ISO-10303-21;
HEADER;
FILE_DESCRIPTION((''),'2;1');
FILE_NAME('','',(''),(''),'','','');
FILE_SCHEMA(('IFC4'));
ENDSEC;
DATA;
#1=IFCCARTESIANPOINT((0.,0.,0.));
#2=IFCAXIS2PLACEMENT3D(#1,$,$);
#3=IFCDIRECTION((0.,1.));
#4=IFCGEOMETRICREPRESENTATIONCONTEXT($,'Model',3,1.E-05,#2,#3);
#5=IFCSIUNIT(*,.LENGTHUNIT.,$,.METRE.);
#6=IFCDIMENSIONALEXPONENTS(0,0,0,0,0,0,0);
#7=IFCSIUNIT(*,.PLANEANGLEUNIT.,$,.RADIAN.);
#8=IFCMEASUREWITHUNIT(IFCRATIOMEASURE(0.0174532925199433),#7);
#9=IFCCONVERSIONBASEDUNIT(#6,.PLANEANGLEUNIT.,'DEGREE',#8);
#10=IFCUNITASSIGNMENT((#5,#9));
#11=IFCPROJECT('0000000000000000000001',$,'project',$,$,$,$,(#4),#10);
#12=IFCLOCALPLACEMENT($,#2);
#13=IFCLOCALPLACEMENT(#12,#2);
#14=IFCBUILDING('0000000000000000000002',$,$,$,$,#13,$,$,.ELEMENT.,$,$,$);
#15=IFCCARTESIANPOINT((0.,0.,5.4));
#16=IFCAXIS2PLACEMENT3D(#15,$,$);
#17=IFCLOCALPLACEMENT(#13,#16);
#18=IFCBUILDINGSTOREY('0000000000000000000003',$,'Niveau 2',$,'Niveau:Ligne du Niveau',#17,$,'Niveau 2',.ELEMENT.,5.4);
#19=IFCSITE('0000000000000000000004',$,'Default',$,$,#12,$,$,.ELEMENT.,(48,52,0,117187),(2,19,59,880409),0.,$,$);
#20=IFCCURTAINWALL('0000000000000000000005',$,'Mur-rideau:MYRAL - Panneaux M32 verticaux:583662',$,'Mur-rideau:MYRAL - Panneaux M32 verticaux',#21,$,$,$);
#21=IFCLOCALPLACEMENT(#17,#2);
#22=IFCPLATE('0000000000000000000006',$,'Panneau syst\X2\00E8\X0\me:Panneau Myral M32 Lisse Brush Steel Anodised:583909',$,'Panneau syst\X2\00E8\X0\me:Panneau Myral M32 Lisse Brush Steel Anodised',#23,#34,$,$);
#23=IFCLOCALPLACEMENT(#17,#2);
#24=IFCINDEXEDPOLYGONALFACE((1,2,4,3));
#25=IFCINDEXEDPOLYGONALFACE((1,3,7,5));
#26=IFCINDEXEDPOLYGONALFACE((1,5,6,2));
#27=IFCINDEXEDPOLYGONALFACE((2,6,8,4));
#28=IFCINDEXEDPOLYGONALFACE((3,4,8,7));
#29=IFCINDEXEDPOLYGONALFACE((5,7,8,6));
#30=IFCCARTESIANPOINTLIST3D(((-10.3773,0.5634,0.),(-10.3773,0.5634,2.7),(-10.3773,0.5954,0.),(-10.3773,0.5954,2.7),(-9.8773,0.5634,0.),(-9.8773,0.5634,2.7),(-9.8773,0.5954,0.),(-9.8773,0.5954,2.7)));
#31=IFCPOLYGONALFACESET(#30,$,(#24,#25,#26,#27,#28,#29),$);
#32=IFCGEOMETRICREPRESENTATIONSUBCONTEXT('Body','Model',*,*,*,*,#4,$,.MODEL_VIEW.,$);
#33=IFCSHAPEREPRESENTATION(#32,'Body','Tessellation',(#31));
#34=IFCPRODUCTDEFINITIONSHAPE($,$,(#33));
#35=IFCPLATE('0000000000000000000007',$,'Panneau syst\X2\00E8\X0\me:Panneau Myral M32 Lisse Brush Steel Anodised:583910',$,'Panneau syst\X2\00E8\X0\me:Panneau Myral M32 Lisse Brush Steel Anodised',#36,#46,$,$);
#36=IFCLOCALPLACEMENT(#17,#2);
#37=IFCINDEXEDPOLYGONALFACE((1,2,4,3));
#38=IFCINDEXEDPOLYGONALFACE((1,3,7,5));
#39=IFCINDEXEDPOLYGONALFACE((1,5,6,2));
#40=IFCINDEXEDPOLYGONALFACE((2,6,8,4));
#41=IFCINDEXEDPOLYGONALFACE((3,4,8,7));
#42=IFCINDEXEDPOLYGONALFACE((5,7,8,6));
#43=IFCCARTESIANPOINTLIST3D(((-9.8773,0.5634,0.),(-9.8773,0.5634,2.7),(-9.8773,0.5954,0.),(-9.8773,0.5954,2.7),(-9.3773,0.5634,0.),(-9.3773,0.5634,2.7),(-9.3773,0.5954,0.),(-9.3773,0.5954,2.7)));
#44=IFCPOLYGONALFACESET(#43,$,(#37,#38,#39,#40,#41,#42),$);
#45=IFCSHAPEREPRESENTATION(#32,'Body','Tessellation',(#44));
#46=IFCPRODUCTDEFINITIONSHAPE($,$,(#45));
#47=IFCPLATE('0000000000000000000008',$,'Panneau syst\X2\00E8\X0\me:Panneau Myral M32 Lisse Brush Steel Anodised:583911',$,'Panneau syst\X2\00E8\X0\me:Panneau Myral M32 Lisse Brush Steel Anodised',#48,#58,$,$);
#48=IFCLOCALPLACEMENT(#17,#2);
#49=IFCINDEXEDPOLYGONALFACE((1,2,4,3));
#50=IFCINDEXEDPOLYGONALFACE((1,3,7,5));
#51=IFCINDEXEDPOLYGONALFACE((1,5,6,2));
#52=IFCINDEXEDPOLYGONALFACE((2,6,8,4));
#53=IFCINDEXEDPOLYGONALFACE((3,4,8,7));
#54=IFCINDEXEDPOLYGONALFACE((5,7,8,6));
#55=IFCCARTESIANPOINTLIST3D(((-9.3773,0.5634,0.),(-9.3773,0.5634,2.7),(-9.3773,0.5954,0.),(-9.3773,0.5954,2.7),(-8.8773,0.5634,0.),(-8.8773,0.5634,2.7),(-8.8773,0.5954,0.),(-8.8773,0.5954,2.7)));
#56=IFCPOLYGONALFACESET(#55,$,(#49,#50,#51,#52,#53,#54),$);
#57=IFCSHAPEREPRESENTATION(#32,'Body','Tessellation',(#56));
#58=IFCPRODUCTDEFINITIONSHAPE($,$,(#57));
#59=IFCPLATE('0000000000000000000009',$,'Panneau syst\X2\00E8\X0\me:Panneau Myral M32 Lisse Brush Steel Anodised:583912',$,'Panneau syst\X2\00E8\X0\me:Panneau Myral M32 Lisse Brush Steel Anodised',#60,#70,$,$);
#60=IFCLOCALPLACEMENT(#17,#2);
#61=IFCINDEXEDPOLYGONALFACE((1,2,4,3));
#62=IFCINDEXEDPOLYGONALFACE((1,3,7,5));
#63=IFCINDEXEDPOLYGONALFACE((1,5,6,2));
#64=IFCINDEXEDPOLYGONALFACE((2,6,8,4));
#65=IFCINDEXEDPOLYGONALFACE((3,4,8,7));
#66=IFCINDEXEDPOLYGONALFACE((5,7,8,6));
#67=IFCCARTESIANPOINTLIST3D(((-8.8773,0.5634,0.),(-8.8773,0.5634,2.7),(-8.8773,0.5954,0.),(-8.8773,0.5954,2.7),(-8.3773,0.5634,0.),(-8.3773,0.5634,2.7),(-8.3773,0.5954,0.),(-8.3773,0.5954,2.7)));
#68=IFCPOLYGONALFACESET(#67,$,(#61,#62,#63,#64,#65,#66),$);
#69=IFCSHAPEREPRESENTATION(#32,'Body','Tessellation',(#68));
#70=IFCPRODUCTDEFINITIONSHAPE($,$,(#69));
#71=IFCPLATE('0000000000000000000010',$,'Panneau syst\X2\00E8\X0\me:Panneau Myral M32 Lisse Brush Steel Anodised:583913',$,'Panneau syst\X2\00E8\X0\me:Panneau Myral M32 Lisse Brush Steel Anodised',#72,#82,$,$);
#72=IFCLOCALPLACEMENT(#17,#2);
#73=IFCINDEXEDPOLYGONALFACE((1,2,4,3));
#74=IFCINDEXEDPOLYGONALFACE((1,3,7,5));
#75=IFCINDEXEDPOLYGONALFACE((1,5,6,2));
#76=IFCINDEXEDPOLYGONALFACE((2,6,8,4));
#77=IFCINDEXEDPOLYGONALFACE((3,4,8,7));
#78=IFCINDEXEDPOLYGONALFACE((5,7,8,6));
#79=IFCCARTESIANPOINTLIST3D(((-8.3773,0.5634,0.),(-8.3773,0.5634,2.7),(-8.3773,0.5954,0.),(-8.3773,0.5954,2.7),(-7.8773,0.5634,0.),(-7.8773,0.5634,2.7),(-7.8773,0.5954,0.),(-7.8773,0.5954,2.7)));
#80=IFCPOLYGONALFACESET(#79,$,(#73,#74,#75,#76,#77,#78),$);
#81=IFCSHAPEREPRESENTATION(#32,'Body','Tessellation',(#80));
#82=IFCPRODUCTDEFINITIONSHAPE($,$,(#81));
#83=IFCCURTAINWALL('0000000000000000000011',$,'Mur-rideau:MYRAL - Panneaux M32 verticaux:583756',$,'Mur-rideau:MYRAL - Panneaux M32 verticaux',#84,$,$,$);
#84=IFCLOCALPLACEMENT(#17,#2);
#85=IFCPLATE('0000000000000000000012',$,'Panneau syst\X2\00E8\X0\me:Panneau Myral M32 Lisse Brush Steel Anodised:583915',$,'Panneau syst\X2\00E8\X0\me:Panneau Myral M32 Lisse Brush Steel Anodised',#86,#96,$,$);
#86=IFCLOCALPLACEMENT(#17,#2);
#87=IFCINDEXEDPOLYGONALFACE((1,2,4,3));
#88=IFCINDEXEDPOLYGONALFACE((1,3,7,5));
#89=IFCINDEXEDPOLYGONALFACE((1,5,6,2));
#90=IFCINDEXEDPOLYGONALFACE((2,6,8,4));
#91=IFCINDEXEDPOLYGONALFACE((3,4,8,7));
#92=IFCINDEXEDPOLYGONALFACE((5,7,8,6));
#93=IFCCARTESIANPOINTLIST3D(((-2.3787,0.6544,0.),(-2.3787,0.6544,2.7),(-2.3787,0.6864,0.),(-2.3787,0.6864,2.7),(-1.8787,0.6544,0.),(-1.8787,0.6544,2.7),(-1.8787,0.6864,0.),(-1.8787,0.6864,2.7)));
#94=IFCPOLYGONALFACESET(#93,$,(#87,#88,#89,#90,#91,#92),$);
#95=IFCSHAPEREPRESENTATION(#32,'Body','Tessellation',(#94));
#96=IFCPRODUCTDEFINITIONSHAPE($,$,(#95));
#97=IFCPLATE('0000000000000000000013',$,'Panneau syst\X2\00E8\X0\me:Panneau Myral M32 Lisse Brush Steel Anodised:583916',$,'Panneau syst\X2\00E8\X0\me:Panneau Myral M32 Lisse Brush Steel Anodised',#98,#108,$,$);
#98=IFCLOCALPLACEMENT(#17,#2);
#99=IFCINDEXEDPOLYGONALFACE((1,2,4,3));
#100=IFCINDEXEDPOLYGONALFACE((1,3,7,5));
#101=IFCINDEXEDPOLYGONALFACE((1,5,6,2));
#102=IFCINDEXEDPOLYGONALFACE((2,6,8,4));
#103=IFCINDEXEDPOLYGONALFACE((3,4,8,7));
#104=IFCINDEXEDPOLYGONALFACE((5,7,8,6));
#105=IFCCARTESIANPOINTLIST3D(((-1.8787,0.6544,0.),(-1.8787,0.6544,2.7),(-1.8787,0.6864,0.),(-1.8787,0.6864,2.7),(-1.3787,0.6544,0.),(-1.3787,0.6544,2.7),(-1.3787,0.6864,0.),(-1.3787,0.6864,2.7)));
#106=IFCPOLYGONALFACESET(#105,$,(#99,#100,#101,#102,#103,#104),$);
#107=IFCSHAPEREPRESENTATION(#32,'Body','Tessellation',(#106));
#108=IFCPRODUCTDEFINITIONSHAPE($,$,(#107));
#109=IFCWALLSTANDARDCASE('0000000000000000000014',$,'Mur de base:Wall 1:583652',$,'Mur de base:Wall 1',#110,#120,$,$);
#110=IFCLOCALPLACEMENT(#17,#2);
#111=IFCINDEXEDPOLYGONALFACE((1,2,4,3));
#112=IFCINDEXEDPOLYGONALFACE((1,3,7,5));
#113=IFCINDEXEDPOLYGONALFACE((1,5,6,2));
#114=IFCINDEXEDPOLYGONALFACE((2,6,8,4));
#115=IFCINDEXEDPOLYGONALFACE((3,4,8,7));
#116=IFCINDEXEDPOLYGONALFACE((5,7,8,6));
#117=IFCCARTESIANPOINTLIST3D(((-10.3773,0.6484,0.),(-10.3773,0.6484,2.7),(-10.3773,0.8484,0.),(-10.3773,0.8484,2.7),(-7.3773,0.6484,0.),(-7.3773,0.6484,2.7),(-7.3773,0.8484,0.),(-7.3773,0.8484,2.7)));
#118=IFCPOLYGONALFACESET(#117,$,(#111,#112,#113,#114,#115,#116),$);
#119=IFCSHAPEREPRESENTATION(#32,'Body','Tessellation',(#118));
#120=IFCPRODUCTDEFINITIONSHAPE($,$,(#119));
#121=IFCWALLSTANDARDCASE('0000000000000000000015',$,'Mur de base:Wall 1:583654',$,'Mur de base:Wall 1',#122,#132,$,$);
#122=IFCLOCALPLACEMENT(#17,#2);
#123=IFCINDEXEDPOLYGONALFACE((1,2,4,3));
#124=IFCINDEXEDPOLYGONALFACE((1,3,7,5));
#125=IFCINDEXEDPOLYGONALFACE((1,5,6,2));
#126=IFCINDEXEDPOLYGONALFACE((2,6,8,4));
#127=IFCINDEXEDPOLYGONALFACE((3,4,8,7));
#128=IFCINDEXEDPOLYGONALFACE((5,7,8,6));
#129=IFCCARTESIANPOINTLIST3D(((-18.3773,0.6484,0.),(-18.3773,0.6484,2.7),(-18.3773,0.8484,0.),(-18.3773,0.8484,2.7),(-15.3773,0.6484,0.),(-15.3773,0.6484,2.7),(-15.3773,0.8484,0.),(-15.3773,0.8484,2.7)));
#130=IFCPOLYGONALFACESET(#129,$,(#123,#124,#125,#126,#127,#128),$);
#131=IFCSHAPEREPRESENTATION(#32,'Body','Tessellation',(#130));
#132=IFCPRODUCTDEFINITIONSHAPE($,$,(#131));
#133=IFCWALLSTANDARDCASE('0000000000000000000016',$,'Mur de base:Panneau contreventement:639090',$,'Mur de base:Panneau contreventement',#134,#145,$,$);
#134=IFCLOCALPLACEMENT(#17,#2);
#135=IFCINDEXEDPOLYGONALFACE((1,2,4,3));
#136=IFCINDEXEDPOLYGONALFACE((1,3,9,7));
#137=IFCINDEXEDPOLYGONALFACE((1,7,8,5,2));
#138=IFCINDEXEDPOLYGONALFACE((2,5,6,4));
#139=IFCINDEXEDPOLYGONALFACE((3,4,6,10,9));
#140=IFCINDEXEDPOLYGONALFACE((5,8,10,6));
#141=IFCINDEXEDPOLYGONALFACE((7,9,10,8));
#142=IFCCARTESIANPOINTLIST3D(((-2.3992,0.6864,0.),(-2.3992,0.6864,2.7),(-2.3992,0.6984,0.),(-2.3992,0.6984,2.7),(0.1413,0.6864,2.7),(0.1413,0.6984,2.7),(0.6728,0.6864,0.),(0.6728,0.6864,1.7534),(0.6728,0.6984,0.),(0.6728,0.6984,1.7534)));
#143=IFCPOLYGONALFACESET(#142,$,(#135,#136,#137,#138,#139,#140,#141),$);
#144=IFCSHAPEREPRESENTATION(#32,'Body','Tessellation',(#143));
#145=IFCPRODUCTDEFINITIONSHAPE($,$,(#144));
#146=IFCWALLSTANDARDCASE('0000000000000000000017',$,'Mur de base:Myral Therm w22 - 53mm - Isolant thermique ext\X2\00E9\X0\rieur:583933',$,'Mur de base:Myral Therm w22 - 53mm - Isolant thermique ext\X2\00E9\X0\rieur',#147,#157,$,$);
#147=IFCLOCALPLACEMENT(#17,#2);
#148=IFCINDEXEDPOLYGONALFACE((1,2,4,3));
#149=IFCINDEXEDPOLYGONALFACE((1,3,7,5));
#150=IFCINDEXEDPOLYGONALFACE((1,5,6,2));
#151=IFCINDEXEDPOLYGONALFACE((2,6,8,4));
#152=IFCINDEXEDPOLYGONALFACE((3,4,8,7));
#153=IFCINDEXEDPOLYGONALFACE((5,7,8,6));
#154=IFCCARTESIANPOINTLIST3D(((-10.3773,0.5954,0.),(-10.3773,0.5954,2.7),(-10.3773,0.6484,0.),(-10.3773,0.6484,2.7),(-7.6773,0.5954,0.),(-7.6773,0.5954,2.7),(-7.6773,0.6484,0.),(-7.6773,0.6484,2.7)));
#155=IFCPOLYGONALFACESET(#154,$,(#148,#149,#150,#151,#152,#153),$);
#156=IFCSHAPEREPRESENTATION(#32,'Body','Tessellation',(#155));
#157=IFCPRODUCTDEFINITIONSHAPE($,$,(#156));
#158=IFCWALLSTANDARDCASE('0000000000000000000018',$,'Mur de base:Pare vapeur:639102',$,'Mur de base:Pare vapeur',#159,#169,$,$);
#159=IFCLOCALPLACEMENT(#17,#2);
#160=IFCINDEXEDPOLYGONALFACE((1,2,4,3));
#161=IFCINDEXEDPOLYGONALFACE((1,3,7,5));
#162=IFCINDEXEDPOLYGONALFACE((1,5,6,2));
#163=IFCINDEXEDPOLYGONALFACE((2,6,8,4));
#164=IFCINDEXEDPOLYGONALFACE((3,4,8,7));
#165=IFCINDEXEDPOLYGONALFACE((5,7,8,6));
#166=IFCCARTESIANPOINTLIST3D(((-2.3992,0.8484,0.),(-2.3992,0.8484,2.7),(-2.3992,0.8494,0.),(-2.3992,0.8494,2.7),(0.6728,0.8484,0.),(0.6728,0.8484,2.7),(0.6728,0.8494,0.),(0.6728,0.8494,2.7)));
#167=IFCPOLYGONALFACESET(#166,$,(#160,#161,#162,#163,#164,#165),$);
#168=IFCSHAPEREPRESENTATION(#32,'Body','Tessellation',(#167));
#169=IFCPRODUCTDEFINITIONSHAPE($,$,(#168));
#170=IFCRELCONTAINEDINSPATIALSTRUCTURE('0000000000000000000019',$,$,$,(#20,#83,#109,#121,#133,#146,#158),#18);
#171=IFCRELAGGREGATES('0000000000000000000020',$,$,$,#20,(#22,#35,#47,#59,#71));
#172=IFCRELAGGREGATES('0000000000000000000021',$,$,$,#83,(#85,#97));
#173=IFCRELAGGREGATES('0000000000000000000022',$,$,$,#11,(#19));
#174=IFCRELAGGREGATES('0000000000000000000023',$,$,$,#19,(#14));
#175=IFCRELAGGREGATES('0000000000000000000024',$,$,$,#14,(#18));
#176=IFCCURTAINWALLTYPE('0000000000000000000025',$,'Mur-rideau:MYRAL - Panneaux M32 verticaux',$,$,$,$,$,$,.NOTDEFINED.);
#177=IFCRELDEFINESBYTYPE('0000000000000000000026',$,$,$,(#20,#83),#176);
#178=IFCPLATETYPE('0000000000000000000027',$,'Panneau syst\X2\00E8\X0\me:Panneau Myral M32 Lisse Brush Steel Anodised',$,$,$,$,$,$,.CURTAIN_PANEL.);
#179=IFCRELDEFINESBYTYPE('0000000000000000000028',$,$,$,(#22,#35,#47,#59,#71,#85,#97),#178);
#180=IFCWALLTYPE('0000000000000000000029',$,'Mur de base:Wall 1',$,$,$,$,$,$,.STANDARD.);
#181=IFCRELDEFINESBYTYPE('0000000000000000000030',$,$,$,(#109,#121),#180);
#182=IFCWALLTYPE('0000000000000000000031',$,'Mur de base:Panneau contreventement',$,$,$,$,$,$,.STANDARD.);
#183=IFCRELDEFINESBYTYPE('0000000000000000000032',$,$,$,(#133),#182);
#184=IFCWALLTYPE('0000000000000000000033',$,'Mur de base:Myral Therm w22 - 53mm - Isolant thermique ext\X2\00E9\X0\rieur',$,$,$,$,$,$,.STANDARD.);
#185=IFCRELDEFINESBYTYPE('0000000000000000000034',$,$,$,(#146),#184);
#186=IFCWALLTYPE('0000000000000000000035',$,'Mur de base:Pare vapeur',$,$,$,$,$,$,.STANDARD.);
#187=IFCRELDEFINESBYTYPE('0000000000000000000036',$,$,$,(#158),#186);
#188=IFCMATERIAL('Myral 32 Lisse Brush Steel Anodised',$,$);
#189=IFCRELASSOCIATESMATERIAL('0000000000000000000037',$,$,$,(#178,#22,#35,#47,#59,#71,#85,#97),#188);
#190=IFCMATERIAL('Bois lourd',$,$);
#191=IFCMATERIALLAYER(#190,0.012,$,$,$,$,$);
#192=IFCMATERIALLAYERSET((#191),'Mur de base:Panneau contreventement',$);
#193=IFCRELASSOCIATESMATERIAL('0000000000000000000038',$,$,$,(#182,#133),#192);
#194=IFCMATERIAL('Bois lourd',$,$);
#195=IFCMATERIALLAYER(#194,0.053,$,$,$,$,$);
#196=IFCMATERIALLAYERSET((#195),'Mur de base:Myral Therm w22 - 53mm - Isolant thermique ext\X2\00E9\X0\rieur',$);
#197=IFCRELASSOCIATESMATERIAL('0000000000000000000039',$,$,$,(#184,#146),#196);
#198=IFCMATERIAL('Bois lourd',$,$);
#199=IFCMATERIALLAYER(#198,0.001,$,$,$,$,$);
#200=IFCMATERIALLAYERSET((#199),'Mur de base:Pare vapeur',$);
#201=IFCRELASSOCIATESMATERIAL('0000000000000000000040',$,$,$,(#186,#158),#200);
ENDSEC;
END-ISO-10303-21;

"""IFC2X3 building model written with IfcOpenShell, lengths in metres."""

from ifc_helpers import new_model, entity, si_unit, converted_unit, direction, frame, frame_2d, origin, origin_2d_with_axis, place, context, subcontext, project, spatial, rectangle, extrude, clip, halfspace, source, transform, mapped, material, layer, layer_set, layer_usage, type_object, type_shapes, element, aggregate, save


model = new_model("IFC2X3")

# Units and contexts
model_context = context("Model", 3, precision=1e-05, world=origin(), true_north=direction((0.0, 1.0)))
body_context = subcontext(model_context, "Body", "Model", "MODEL_VIEW")
ifc_project = project(units=[si_unit("LENGTHUNIT", "METRE"), converted_unit("PLANEANGLEUNIT", "DEGREE", entity("IfcRatioMeasure", 0.0174532925199433), si_unit("PLANEANGLEUNIT", "RADIAN"), dimensions=[0, 0, 0, 0, 0, 0, 0])], contexts=[model_context])

# Site, building, storey
site_placement = place(None, origin())
site = spatial("IfcSite", under=ifc_project, at=site_placement, Name="Default", CompositionType="ELEMENT", RefLatitude=(48, 52, 0, 117187), RefLongitude=(2, 19, 59, 880409), RefElevation=0.0)
building_placement = place(site_placement, origin())
building = spatial("IfcBuilding", under=site, at=building_placement, CompositionType="ELEMENT")
storey_placement = place(building_placement, frame((0.0, 0.0, 5.4)))
storey = spatial("IfcBuildingStorey", under=building, at=storey_placement, Name="Niveau 2", ObjectType="Niveau:Ligne du Niveau", LongName="Niveau 2", CompositionType="ELEMENT", Elevation=5.4)

# Shared definitions
ifc_material_1 = material(Name="Bois lourd")

# Curtain walls, plates
curtain_wall_type_1 = type_object("IfcCurtainWallType", Name="Mur-rideau:MYRAL - Panneaux M32 verticaux", PredefinedType="NOTDEFINED")
ifc_material_2 = material(Name="Myral 32 Lisse Brush Steel Anodised")
plate_type = type_object("IfcPlateType", Name="Panneau système:Panneau Myral M32 Lisse Brush Steel Anodised", PredefinedType="CURTAIN_PANEL", material=ifc_material_2)
shared_shape_1 = source(origin(), body_context, "Body", "SweptSolid", [
    extrude(rectangle(XDim=0.032, YDim=0.5, at=origin_2d_with_axis()), frame((0.0, -0.016, 0.0), z_axis=(0.0, 0.0, 1.0), x_axis=(0.0, 1.0, 0.0)), (0.0, 0.0, 1.0), 2.7),
])
type_shapes(plate_type, [shared_shape_1])
curtain_wall_1_placement = place(storey_placement, frame((0.0, 0.0, -5.4)))
curtain_wall_1 = element("IfcCurtainWall", 1, at=curtain_wall_1_placement, inside=storey, type_object=curtain_wall_type_1, Name="Mur-rideau:MYRAL - Panneaux M32 verticaux:583662", ObjectType="Mur-rideau:MYRAL - Panneaux M32 verticaux")
plate_1_placement = place(curtain_wall_1_placement, frame((-10.1273, 0.5954, 5.4)))
plate_1 = element("IfcPlate", 2, at=plate_1_placement, type_object=plate_type, material=ifc_material_2, Name="Panneau système:Panneau Myral M32 Lisse Brush Steel Anodised:583909", ObjectType="Panneau système:Panneau Myral M32 Lisse Brush Steel Anodised", context=body_context, shape_type="MappedRepresentation", body=[
    mapped(shared_shape_1, transform((0.0, 0.0, 0.0), scale=1.0)),
])
plate_2_placement = place(curtain_wall_1_placement, frame((-9.6273, 0.5954, 5.4)))
plate_2 = element("IfcPlate", 3, at=plate_2_placement, type_object=plate_type, material=ifc_material_2, Name="Panneau système:Panneau Myral M32 Lisse Brush Steel Anodised:583910", ObjectType="Panneau système:Panneau Myral M32 Lisse Brush Steel Anodised", context=body_context, shape_type="MappedRepresentation", body=[
    mapped(shared_shape_1, transform((0.0, 0.0, 0.0), scale=1.0)),
])
plate_3_placement = place(curtain_wall_1_placement, frame((-9.1273, 0.5954, 5.4)))
plate_3 = element("IfcPlate", 4, at=plate_3_placement, type_object=plate_type, material=ifc_material_2, Name="Panneau système:Panneau Myral M32 Lisse Brush Steel Anodised:583911", ObjectType="Panneau système:Panneau Myral M32 Lisse Brush Steel Anodised", context=body_context, shape_type="MappedRepresentation", body=[
    mapped(shared_shape_1, transform((0.0, 0.0, 0.0), scale=1.0)),
])
plate_4_placement = place(curtain_wall_1_placement, frame((-8.6273, 0.5954, 5.4)))
plate_4 = element("IfcPlate", 5, at=plate_4_placement, type_object=plate_type, material=ifc_material_2, Name="Panneau système:Panneau Myral M32 Lisse Brush Steel Anodised:583912", ObjectType="Panneau système:Panneau Myral M32 Lisse Brush Steel Anodised", context=body_context, shape_type="MappedRepresentation", body=[
    mapped(shared_shape_1, transform((0.0, 0.0, 0.0), scale=1.0)),
])
plate_5_placement = place(curtain_wall_1_placement, frame((-8.1273, 0.5954, 5.4)))
plate_5 = element("IfcPlate", 6, at=plate_5_placement, type_object=plate_type, material=ifc_material_2, Name="Panneau système:Panneau Myral M32 Lisse Brush Steel Anodised:583913", ObjectType="Panneau système:Panneau Myral M32 Lisse Brush Steel Anodised", context=body_context, shape_type="MappedRepresentation", body=[
    mapped(shared_shape_1, transform((0.0, 0.0, 0.0), scale=1.0)),
])
aggregate(curtain_wall_1, [plate_1, plate_2, plate_3, plate_4, plate_5])
curtain_wall_2_placement = place(storey_placement, frame((0.0, 0.0, -5.4)))
curtain_wall_2 = element("IfcCurtainWall", 7, at=curtain_wall_2_placement, inside=storey, type_object=curtain_wall_type_1, Name="Mur-rideau:MYRAL - Panneaux M32 verticaux:583756", ObjectType="Mur-rideau:MYRAL - Panneaux M32 verticaux")
plate_6_placement = place(curtain_wall_2_placement, frame((-2.1287, 0.6864, 5.4)))
plate_6 = element("IfcPlate", 8, at=plate_6_placement, type_object=plate_type, material=ifc_material_2, Name="Panneau système:Panneau Myral M32 Lisse Brush Steel Anodised:583915", ObjectType="Panneau système:Panneau Myral M32 Lisse Brush Steel Anodised", context=body_context, shape_type="MappedRepresentation", body=[
    mapped(shared_shape_1, transform((0.0, 0.0, 0.0), scale=1.0)),
])
plate_7_placement = place(curtain_wall_2_placement, frame((-1.6287, 0.6864, 5.4)))
plate_7 = element("IfcPlate", 9, at=plate_7_placement, type_object=plate_type, material=ifc_material_2, Name="Panneau système:Panneau Myral M32 Lisse Brush Steel Anodised:583916", ObjectType="Panneau système:Panneau Myral M32 Lisse Brush Steel Anodised", context=body_context, shape_type="MappedRepresentation", body=[
    mapped(shared_shape_1, transform((0.0, 0.0, 0.0), scale=1.0)),
])
aggregate(curtain_wall_2, [plate_6, plate_7])

# Walls
wall_type_1 = type_object("IfcWallType", Name="Mur de base:Wall 1", PredefinedType="STANDARD")
for number, where, name in (
    (10, (-10.3773, 0.7484, 0.0), "Mur de base:Wall 1:583652"),
    (11, (-18.3773, 0.7484, 0.0), "Mur de base:Wall 1:583654"),
):
    element("IfcWallStandardCase", number, at=place(storey_placement, frame(where)), inside=storey, type_object=wall_type_1, Name=name, ObjectType="Mur de base:Wall 1", context=body_context, shape_type="SweptSolid", body=[
        extrude(rectangle(XDim=3.0, YDim=0.2, at=frame_2d((1.5, 0.0), x_axis=(-1.0, 0.0))), origin(), (0.0, 0.0, 1.0), 2.7),
    ])
ifc_layer_1 = layer(ifc_material_1, 0.012)
ifc_layer_set_1 = layer_set([ifc_layer_1], Name="Mur de base:Panneau contreventement")
ifc_layer_usage_1 = layer_usage(ifc_layer_set_1, "AXIS2", "NEGATIVE", 0.006)
wall_type_2 = type_object("IfcWallType", Name="Mur de base:Panneau contreventement", PredefinedType="STANDARD", material=ifc_layer_set_1)
wall_1_placement = place(storey_placement, frame((-2.3992, 0.6924, 0.0)))
element("IfcWallStandardCase", 12, at=wall_1_placement, inside=storey, type_object=wall_type_2, material=ifc_layer_usage_1, Name="Mur de base:Panneau contreventement:639090", ObjectType="Mur de base:Panneau contreventement", context=body_context, shape_type="Clipping", body=[
    clip(extrude(rectangle(XDim=3.072, YDim=0.012, at=frame_2d((1.536, 0.0), x_axis=(-1.0, 0.0))), origin(), (0.0, 0.0, 1.0), 2.7), halfspace(frame((2.5405, -0.006, 2.7), z_axis=(0.871952, 0.0, 0.489592), x_axis=(0.0, 1.0, 0.0)), False)),
])
ifc_material_3 = material(Name="Bois lourd")
ifc_layer_2 = layer(ifc_material_3, 0.053)
ifc_layer_set_2 = layer_set([ifc_layer_2], Name="Mur de base:Myral Therm w22 - 53mm - Isolant thermique extérieur")
ifc_layer_usage_2 = layer_usage(ifc_layer_set_2, "AXIS2", "NEGATIVE", 0.0265)
wall_type_3 = type_object("IfcWallType", Name="Mur de base:Myral Therm w22 - 53mm - Isolant thermique extérieur", PredefinedType="STANDARD", material=ifc_layer_set_2)
wall_2_placement = place(storey_placement, frame((-10.3773, 0.6219, 0.0)))
element("IfcWallStandardCase", 13, at=wall_2_placement, inside=storey, type_object=wall_type_3, material=ifc_layer_usage_2, Name="Mur de base:Myral Therm w22 - 53mm - Isolant thermique extérieur:583933", ObjectType="Mur de base:Myral Therm w22 - 53mm - Isolant thermique extérieur", context=body_context, shape_type="SweptSolid", body=[
    extrude(rectangle(XDim=2.7, YDim=0.053, at=frame_2d((1.35, 0.0), x_axis=(-1.0, 0.0))), origin(), (0.0, 0.0, 1.0), 2.7),
])
ifc_material_4 = material(Name="Bois lourd")
ifc_layer_3 = layer(ifc_material_4, 0.001)
ifc_layer_set_3 = layer_set([ifc_layer_3], Name="Mur de base:Pare vapeur")
ifc_layer_usage_3 = layer_usage(ifc_layer_set_3, "AXIS2", "NEGATIVE", 0.0005)
wall_type_4 = type_object("IfcWallType", Name="Mur de base:Pare vapeur", PredefinedType="STANDARD", material=ifc_layer_set_3)
wall_3_placement = place(storey_placement, frame((-2.3992, 0.8489, 0.0)))
element("IfcWallStandardCase", 14, at=wall_3_placement, inside=storey, type_object=wall_type_4, material=ifc_layer_usage_3, Name="Mur de base:Pare vapeur:639102", ObjectType="Mur de base:Pare vapeur", context=body_context, shape_type="SweptSolid", body=[
    extrude(rectangle(XDim=3.072, YDim=0.001, at=frame_2d((1.536, 0.0), x_axis=(-1.0, 0.0))), origin(), (0.0, 0.0, 1.0), 2.7),
])

save(model, "model.ifc")
